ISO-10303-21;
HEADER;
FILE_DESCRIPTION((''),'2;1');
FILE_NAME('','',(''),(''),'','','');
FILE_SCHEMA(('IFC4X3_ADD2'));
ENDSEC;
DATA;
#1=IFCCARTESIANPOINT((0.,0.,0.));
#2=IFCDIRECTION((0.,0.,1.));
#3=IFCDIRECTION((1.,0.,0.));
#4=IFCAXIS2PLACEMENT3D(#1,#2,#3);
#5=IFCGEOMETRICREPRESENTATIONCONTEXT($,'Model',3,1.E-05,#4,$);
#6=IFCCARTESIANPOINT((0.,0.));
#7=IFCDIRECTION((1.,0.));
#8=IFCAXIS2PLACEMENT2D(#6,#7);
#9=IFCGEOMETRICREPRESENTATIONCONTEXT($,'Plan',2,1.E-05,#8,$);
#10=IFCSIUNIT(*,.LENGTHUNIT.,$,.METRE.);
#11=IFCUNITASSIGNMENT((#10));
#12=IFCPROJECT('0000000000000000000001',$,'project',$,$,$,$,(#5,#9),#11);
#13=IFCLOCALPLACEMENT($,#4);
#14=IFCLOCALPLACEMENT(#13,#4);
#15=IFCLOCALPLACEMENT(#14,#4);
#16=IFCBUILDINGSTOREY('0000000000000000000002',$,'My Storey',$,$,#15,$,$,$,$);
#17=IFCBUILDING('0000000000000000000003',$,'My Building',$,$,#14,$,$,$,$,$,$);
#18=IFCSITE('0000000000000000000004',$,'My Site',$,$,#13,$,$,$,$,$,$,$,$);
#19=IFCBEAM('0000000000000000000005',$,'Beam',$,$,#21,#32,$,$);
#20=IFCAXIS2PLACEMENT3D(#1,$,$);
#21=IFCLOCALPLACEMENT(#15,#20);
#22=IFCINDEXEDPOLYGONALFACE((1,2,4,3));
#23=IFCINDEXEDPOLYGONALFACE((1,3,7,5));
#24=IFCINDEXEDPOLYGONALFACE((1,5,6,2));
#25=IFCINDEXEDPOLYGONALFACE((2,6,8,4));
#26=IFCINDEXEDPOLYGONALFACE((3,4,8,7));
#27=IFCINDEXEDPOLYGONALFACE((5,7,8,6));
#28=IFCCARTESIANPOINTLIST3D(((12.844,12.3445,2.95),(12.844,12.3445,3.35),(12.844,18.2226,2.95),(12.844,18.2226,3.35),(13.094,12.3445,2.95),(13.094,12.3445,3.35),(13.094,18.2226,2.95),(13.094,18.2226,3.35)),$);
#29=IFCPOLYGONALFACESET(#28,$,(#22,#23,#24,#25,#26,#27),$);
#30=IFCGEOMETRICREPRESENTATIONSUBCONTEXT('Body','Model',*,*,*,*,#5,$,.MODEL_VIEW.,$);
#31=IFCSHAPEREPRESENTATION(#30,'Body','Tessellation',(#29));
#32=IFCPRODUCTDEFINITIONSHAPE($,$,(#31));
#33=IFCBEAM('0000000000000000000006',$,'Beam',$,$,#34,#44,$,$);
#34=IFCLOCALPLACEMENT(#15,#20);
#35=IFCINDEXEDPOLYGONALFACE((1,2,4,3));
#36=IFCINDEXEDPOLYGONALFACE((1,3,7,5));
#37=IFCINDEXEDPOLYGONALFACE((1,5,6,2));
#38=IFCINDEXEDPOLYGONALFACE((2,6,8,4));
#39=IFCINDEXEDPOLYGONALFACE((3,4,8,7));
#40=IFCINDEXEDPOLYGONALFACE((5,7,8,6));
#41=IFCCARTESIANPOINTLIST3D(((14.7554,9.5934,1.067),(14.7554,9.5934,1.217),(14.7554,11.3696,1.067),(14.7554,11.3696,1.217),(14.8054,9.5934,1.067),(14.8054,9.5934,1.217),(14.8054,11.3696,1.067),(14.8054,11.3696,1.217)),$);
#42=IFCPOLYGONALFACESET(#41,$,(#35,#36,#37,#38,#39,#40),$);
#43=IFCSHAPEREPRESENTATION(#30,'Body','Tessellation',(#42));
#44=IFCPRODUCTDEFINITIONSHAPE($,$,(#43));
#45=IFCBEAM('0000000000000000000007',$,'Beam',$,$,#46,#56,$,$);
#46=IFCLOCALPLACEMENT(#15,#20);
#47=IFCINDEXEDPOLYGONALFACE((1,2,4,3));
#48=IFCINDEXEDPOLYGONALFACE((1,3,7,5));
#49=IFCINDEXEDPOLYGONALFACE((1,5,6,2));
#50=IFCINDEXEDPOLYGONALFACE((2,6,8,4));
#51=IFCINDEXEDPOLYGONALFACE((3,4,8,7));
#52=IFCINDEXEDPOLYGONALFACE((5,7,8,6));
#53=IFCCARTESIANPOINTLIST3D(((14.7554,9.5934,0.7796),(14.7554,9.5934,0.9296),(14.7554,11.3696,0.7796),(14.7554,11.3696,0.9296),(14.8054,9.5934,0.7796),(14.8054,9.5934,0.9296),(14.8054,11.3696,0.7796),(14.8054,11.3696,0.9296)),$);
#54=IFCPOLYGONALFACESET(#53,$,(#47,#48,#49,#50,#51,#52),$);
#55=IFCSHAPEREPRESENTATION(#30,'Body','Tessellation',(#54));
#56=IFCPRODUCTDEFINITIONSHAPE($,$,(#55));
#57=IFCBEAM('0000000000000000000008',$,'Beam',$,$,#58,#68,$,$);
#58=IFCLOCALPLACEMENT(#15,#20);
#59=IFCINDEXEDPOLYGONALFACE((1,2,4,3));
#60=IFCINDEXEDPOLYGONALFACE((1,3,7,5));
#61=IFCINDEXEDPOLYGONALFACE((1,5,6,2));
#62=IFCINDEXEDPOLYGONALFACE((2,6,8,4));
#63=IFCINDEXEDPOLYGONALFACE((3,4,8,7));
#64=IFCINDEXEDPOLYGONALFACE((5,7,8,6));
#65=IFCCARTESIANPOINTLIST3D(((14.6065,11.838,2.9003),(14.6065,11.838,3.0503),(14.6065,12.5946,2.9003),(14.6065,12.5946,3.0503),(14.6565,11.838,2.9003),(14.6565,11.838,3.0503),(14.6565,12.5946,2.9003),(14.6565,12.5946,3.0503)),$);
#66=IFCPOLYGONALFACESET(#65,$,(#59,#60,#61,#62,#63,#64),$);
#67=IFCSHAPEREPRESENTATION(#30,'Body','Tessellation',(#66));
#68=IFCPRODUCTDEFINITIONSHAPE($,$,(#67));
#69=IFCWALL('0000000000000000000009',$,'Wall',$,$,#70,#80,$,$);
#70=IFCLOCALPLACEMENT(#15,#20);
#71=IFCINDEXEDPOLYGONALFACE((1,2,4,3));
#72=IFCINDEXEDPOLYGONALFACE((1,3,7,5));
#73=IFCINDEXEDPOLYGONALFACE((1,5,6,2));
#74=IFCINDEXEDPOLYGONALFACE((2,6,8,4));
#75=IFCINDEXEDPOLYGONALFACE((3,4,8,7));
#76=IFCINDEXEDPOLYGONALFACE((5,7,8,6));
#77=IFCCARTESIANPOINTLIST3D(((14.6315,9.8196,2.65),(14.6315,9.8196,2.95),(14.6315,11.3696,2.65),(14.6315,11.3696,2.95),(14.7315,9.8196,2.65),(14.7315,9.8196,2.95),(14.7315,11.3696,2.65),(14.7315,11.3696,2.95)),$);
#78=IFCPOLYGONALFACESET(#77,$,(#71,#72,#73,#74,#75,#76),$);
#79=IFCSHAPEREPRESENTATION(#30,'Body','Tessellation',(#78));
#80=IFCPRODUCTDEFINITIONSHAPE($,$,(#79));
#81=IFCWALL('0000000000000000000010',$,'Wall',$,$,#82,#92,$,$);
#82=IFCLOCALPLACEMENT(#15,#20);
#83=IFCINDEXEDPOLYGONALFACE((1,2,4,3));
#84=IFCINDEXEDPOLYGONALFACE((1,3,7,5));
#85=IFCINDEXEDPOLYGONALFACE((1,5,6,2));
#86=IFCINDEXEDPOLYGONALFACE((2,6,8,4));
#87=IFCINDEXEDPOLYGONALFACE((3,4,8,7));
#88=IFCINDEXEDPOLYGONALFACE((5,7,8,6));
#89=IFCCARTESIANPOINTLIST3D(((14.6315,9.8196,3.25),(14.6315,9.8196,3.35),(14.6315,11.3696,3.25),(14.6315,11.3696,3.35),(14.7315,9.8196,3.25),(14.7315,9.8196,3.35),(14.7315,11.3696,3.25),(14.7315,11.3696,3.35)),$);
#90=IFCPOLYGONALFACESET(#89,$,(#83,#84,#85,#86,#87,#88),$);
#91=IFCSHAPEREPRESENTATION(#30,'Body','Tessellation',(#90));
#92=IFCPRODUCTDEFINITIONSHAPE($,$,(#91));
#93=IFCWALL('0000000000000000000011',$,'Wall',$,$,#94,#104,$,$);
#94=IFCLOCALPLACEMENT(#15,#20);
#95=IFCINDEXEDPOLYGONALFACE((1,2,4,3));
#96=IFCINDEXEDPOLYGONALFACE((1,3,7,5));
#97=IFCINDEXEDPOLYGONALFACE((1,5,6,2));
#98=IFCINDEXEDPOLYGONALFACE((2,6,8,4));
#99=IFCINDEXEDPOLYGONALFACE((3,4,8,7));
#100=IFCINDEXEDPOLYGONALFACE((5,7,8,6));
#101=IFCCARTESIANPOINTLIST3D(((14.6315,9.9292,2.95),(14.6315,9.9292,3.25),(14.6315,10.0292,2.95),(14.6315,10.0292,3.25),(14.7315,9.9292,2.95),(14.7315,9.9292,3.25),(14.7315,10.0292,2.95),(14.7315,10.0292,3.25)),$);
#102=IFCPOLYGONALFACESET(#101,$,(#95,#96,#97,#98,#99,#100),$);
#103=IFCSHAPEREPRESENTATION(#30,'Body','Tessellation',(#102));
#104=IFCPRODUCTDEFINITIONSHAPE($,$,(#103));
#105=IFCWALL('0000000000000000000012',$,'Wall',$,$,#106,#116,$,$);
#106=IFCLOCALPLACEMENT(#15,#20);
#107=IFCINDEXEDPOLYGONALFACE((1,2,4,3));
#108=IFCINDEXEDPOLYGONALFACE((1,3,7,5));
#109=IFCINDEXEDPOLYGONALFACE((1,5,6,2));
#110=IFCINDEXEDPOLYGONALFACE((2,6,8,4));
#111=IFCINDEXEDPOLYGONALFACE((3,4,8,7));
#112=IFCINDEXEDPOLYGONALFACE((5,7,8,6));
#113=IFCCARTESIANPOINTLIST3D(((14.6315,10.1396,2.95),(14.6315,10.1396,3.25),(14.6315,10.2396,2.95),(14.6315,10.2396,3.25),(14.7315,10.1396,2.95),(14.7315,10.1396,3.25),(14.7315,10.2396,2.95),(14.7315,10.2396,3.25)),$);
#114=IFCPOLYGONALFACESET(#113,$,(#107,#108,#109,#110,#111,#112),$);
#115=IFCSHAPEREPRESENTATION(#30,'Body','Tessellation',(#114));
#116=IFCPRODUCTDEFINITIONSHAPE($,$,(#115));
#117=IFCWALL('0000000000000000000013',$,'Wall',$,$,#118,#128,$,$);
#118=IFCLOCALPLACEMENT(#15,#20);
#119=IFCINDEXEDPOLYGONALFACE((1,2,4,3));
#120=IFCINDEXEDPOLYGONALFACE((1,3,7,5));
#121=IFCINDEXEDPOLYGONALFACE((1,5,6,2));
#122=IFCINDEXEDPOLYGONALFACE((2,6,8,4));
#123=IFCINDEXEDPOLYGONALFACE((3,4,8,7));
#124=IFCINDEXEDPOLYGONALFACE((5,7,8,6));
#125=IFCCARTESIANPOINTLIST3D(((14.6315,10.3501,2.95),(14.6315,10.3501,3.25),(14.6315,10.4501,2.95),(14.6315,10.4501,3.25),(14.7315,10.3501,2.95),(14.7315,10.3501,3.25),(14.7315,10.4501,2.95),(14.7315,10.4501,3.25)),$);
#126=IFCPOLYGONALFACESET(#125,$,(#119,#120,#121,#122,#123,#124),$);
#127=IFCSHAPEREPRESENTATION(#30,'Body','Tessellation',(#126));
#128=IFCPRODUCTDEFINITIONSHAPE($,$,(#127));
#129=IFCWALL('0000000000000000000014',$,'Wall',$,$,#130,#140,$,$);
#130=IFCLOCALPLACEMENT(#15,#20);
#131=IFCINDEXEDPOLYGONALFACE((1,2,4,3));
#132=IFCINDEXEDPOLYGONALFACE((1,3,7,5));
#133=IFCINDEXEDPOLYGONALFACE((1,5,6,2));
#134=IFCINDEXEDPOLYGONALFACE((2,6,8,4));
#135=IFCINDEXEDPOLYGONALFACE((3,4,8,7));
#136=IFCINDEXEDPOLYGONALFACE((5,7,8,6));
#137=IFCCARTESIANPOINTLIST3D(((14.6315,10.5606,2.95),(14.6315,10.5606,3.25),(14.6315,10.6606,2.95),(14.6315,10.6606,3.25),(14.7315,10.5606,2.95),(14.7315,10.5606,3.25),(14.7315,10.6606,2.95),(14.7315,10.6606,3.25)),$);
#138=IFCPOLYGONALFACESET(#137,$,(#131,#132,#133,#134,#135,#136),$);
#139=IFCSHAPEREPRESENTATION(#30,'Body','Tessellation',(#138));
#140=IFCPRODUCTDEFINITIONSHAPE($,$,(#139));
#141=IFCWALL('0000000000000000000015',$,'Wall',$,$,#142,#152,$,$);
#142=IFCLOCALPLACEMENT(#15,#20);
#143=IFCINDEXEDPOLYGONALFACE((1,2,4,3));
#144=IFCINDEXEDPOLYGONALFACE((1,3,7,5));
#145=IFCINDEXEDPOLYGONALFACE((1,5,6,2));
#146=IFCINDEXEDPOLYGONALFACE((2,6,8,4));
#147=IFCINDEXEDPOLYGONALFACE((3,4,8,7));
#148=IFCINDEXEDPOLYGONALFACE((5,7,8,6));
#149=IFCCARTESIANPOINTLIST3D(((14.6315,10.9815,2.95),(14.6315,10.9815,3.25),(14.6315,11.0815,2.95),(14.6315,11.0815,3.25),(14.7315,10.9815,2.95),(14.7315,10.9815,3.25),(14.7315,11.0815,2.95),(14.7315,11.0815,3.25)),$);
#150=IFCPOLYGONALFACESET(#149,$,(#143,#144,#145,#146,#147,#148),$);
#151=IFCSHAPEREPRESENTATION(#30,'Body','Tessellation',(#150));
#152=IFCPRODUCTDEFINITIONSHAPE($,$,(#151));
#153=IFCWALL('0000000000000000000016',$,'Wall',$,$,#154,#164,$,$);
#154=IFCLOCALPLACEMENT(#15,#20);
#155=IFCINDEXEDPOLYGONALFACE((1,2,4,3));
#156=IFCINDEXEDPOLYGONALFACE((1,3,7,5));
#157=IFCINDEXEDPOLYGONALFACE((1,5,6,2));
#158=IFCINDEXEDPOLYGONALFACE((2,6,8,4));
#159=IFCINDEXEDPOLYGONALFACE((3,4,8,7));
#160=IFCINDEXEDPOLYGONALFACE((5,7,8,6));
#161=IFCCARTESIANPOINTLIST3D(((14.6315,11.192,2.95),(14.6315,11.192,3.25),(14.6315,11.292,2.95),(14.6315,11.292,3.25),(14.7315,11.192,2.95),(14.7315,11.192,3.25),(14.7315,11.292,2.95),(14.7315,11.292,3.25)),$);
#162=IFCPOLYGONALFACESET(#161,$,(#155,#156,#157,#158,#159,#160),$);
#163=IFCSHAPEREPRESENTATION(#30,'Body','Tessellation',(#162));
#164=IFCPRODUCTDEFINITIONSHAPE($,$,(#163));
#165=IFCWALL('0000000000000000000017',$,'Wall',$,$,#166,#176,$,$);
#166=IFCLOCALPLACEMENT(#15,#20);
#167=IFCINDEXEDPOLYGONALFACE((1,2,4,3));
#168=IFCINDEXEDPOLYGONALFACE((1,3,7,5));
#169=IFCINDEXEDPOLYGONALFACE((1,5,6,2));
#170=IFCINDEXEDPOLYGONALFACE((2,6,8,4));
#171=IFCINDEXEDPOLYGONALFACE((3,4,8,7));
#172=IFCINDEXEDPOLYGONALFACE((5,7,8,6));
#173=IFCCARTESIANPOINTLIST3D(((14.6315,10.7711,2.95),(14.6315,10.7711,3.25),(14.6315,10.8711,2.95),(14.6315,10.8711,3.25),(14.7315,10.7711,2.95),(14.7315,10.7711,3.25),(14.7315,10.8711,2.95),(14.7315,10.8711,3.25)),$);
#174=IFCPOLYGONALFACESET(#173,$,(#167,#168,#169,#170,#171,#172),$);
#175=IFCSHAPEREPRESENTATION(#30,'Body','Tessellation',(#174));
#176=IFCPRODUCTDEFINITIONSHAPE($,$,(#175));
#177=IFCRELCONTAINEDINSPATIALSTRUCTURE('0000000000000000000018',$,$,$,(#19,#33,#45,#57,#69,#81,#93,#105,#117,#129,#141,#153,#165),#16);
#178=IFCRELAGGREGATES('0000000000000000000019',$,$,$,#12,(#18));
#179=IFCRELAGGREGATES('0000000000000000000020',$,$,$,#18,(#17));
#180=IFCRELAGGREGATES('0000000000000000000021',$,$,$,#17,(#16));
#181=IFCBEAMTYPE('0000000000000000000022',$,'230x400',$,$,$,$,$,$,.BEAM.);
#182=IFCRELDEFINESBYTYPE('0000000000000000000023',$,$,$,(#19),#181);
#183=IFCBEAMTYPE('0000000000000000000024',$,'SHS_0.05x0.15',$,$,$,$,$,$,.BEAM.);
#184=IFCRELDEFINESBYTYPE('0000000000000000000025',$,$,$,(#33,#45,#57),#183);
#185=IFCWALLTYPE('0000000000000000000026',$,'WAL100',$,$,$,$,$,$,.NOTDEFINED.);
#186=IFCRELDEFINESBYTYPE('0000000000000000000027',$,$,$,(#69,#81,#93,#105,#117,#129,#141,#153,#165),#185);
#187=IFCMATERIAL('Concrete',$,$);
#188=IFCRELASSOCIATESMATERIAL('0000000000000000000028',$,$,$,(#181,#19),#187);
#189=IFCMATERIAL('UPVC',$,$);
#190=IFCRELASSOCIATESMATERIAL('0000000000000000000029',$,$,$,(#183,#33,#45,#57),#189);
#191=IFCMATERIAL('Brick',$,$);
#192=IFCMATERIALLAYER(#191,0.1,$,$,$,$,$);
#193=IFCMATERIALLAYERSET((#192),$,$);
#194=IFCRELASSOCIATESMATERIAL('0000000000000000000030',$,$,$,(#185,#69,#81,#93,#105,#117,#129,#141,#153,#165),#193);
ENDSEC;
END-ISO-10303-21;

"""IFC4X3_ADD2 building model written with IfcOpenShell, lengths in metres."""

from ifc_helpers import new_model, si_unit, frame, origin_with_axes, origin_2d_with_axis, place, context, subcontext, project, spatial, line, indexed_curve, rectangle, outline, extrude, material, layer, layer_set, layer_usage, material_profile, profile_set, profile_usage, type_object, element, save


model = new_model("IFC4X3_ADD2")

# Units and contexts
model_context = context("Model", 3, precision=1e-05, world=origin_with_axes())
plan_context = context("Plan", 2, precision=1e-05, world=origin_2d_with_axis())
body_context = subcontext(model_context, "Body", "Model", "MODEL_VIEW")
ifc_project = project(units=[si_unit("LENGTHUNIT", "METRE")], contexts=[model_context, plan_context])

# Site, building, storey
site_placement = place(None, origin_with_axes())
site = spatial("IfcSite", under=ifc_project, at=site_placement, Name="My Site")
building_placement = place(site_placement, origin_with_axes())
building = spatial("IfcBuilding", under=site, at=building_placement, Name="My Building")
storey_placement = place(building_placement, origin_with_axes())
storey = spatial("IfcBuildingStorey", under=building, at=storey_placement, Name="My Storey")

# Beams
ifc_material_1 = material(Name="Concrete")
ifc_material_profile_1 = material_profile(ifc_material_1, rectangle(XDim=0.25, YDim=0.4))
ifc_profile_set_1 = profile_set([ifc_material_profile_1])
ifc_profile_usage_1 = profile_usage(ifc_profile_set_1, cardinal=5)
beam_type_1 = type_object("IfcBeamType", Name="230x400", PredefinedType="BEAM", material=ifc_profile_set_1)
beam_1_placement = place(storey_placement, frame((12.969, 12.3445, 3.15), z_axis=(0.0, 1.0, 0.0), x_axis=(-1.0, 0.0, 0.0)))
element("IfcBeam", 1, at=beam_1_placement, inside=storey, type_object=beam_type_1, material=ifc_profile_usage_1, Name="Beam", context=body_context, shape_type="SweptSolid", body=[
    extrude(rectangle(XDim=0.25, YDim=0.4), origin_with_axes(), (0.0, 0.0, 1.0), 5.878),
])
ifc_material_2 = material(Name="UPVC")
ifc_material_profile_2 = material_profile(ifc_material_2, outline(indexed_curve([(-0.025, 0.075), (0.025, 0.075), (0.025, -0.075), (-0.025, -0.075), (-0.025, 0.075)])))
ifc_profile_set_2 = profile_set([ifc_material_profile_2])
ifc_profile_usage_2 = profile_usage(ifc_profile_set_2, cardinal=5)
beam_type_2 = type_object("IfcBeamType", Name="SHS_0.05x0.15", PredefinedType="BEAM", material=ifc_profile_set_2)
beam_2_placement = place(storey_placement, frame((14.7804, 9.5934, 1.142), z_axis=(0.0, 1.0, 0.0), x_axis=(-1.0, 0.0, 0.0)))
element("IfcBeam", 2, at=beam_2_placement, inside=storey, type_object=beam_type_2, material=ifc_profile_usage_2, Name="Beam", context=body_context, shape_type="SweptSolid", body=[
    extrude(outline(indexed_curve([(-0.025, 0.075), (0.025, 0.075), (0.025, -0.075), (-0.025, -0.075), (-0.025, 0.075)])), origin_with_axes(), (0.0, 0.0, 1.0), 1.7762),
])
ifc_profile_usage_3 = profile_usage(ifc_profile_set_2, cardinal=5)
beam_3_placement = place(storey_placement, frame((14.7804, 9.5934, 0.8546), z_axis=(0.0, 1.0, 0.0), x_axis=(-1.0, 0.0, 0.0)))
element("IfcBeam", 3, at=beam_3_placement, inside=storey, type_object=beam_type_2, material=ifc_profile_usage_3, Name="Beam", context=body_context, shape_type="SweptSolid", body=[
    extrude(outline(indexed_curve([(-0.025, 0.075), (0.025, 0.075), (0.025, -0.075), (-0.025, -0.075), (-0.025, 0.075)])), origin_with_axes(), (0.0, 0.0, 1.0), 1.7762),
])
ifc_profile_usage_4 = profile_usage(ifc_profile_set_2, cardinal=5)
beam_4_placement = place(storey_placement, frame((14.6315, 12.5946, 2.9753), z_axis=(0.0, -1.0, 0.0), x_axis=(1.0, 0.0, 0.0)))
element("IfcBeam", 4, at=beam_4_placement, inside=storey, type_object=beam_type_2, material=ifc_profile_usage_4, Name="Beam", context=body_context, shape_type="SweptSolid", body=[
    extrude(outline(indexed_curve([(-0.025, 0.075), (0.025, 0.075), (0.025, -0.075), (-0.025, -0.075), (-0.025, 0.075)])), origin_with_axes(), (0.0, 0.0, 1.0), 0.7566),
])

# Shared definitions
ifc_material_3 = material(Name="Brick")

# Walls
ifc_layer_1 = layer(ifc_material_3, 0.1)
ifc_layer_set_1 = layer_set([ifc_layer_1])
ifc_layer_usage_1 = layer_usage(ifc_layer_set_1, "AXIS2", "NEGATIVE", 0.0)
wall_type_1 = type_object("IfcWallType", Name="WAL100", PredefinedType="NOTDEFINED", material=ifc_layer_set_1)
wall_1_placement = place(storey_placement, frame((14.6315, 9.8196, 2.65), z_axis=(0.0, 0.0, 1.0), x_axis=(-0.000005, 1.0, 0.0)))
element("IfcWall", 5, at=wall_1_placement, inside=storey, type_object=wall_type_1, material=ifc_layer_usage_1, Name="Wall", context=body_context, shape_type="SweptSolid", body=[
    extrude(outline(indexed_curve([(0.0, -0.1), (0.0, 0.0), (1.55, 0.0), (1.55, -0.1)], segments=[line(1, 2, 3, 4, 1)])), origin_with_axes(), (0.0, 0.0, 1.0), 0.3),
])
ifc_layer_usage_2 = layer_usage(ifc_layer_set_1, "AXIS2", "NEGATIVE", 0.0)
wall_2_placement = place(storey_placement, frame((14.6315, 9.8196, 3.25), z_axis=(0.0, 0.0, 1.0), x_axis=(-0.000005, 1.0, 0.0)))
element("IfcWall", 6, at=wall_2_placement, inside=storey, type_object=wall_type_1, material=ifc_layer_usage_2, Name="Wall", context=body_context, shape_type="SweptSolid", body=[
    extrude(outline(indexed_curve([(0.0, -0.1), (0.0, 0.0), (1.55, 0.0), (1.55, -0.1)], segments=[line(1, 2, 3, 4, 1)])), origin_with_axes(), (0.0, 0.0, 1.0), 0.1),
])
ifc_layer_usage_3 = layer_usage(ifc_layer_set_1, "AXIS2", "NEGATIVE", 0.0)
wall_3_placement = place(storey_placement, frame((14.6315, 9.9292, 2.95), z_axis=(0.0, 0.0, 1.0), x_axis=(-0.000005, 1.0, 0.0)))
element("IfcWall", 7, at=wall_3_placement, inside=storey, type_object=wall_type_1, material=ifc_layer_usage_3, Name="Wall", context=body_context, shape_type="SweptSolid", body=[
    extrude(outline(indexed_curve([(0.0, -0.1), (0.0, 0.0), (0.1, 0.0), (0.1, -0.1)], segments=[line(1, 2, 3, 4, 1)])), origin_with_axes(), (0.0, 0.0, 1.0), 0.3),
])
ifc_layer_usage_4 = layer_usage(ifc_layer_set_1, "AXIS2", "NEGATIVE", 0.0)
wall_4_placement = place(storey_placement, frame((14.6315, 10.1396, 2.95), z_axis=(0.0, 0.0, 1.0), x_axis=(-0.000005, 1.0, 0.0)))
element("IfcWall", 8, at=wall_4_placement, inside=storey, type_object=wall_type_1, material=ifc_layer_usage_4, Name="Wall", context=body_context, shape_type="SweptSolid", body=[
    extrude(outline(indexed_curve([(0.0, -0.1), (0.0, 0.0), (0.1, 0.0), (0.1, -0.1)], segments=[line(1, 2, 3, 4, 1)])), origin_with_axes(), (0.0, 0.0, 1.0), 0.3),
])
ifc_layer_usage_5 = layer_usage(ifc_layer_set_1, "AXIS2", "NEGATIVE", 0.0)
wall_5_placement = place(storey_placement, frame((14.6315, 10.3501, 2.95), z_axis=(0.0, 0.0, 1.0), x_axis=(-0.000005, 1.0, 0.0)))
element("IfcWall", 9, at=wall_5_placement, inside=storey, type_object=wall_type_1, material=ifc_layer_usage_5, Name="Wall", context=body_context, shape_type="SweptSolid", body=[
    extrude(outline(indexed_curve([(0.0, -0.1), (0.0, 0.0), (0.1, 0.0), (0.1, -0.1)], segments=[line(1, 2, 3, 4, 1)])), origin_with_axes(), (0.0, 0.0, 1.0), 0.3),
])
ifc_layer_usage_6 = layer_usage(ifc_layer_set_1, "AXIS2", "NEGATIVE", 0.0)
wall_6_placement = place(storey_placement, frame((14.6315, 10.5606, 2.95), z_axis=(0.0, 0.0, 1.0), x_axis=(-0.000005, 1.0, 0.0)))
element("IfcWall", 10, at=wall_6_placement, inside=storey, type_object=wall_type_1, material=ifc_layer_usage_6, Name="Wall", context=body_context, shape_type="SweptSolid", body=[
    extrude(outline(indexed_curve([(0.0, -0.1), (0.0, 0.0), (0.1, 0.0), (0.1, -0.1)], segments=[line(1, 2, 3, 4, 1)])), origin_with_axes(), (0.0, 0.0, 1.0), 0.3),
])
ifc_layer_usage_7 = layer_usage(ifc_layer_set_1, "AXIS2", "NEGATIVE", 0.0)
wall_7_placement = place(storey_placement, frame((14.6315, 10.9815, 2.95), z_axis=(0.0, 0.0, 1.0), x_axis=(-0.000005, 1.0, 0.0)))
element("IfcWall", 11, at=wall_7_placement, inside=storey, type_object=wall_type_1, material=ifc_layer_usage_7, Name="Wall", context=body_context, shape_type="SweptSolid", body=[
    extrude(outline(indexed_curve([(0.0, -0.1), (0.0, 0.0), (0.1, 0.0), (0.1, -0.1)], segments=[line(1, 2, 3, 4, 1)])), origin_with_axes(), (0.0, 0.0, 1.0), 0.3),
])
ifc_layer_usage_8 = layer_usage(ifc_layer_set_1, "AXIS2", "NEGATIVE", 0.0)
wall_8_placement = place(storey_placement, frame((14.6315, 11.192, 2.95), z_axis=(0.0, 0.0, 1.0), x_axis=(-0.000005, 1.0, 0.0)))
element("IfcWall", 12, at=wall_8_placement, inside=storey, type_object=wall_type_1, material=ifc_layer_usage_8, Name="Wall", context=body_context, shape_type="SweptSolid", body=[
    extrude(outline(indexed_curve([(0.0, -0.1), (0.0, 0.0), (0.1, 0.0), (0.1, -0.1)], segments=[line(1, 2, 3, 4, 1)])), origin_with_axes(), (0.0, 0.0, 1.0), 0.3),
])
ifc_layer_usage_9 = layer_usage(ifc_layer_set_1, "AXIS2", "NEGATIVE", 0.0)
wall_9_placement = place(storey_placement, frame((14.6315, 10.7711, 2.95), z_axis=(0.0, 0.0, 1.0), x_axis=(-0.000005, 1.0, 0.0)))
element("IfcWall", 13, at=wall_9_placement, inside=storey, type_object=wall_type_1, material=ifc_layer_usage_9, Name="Wall", context=body_context, shape_type="SweptSolid", body=[
    extrude(outline(indexed_curve([(0.0, -0.1), (0.0, 0.0), (0.1, 0.0), (0.1, -0.1)], segments=[line(1, 2, 3, 4, 1)])), origin_with_axes(), (0.0, 0.0, 1.0), 0.3),
])

save(model, "model.ifc")
